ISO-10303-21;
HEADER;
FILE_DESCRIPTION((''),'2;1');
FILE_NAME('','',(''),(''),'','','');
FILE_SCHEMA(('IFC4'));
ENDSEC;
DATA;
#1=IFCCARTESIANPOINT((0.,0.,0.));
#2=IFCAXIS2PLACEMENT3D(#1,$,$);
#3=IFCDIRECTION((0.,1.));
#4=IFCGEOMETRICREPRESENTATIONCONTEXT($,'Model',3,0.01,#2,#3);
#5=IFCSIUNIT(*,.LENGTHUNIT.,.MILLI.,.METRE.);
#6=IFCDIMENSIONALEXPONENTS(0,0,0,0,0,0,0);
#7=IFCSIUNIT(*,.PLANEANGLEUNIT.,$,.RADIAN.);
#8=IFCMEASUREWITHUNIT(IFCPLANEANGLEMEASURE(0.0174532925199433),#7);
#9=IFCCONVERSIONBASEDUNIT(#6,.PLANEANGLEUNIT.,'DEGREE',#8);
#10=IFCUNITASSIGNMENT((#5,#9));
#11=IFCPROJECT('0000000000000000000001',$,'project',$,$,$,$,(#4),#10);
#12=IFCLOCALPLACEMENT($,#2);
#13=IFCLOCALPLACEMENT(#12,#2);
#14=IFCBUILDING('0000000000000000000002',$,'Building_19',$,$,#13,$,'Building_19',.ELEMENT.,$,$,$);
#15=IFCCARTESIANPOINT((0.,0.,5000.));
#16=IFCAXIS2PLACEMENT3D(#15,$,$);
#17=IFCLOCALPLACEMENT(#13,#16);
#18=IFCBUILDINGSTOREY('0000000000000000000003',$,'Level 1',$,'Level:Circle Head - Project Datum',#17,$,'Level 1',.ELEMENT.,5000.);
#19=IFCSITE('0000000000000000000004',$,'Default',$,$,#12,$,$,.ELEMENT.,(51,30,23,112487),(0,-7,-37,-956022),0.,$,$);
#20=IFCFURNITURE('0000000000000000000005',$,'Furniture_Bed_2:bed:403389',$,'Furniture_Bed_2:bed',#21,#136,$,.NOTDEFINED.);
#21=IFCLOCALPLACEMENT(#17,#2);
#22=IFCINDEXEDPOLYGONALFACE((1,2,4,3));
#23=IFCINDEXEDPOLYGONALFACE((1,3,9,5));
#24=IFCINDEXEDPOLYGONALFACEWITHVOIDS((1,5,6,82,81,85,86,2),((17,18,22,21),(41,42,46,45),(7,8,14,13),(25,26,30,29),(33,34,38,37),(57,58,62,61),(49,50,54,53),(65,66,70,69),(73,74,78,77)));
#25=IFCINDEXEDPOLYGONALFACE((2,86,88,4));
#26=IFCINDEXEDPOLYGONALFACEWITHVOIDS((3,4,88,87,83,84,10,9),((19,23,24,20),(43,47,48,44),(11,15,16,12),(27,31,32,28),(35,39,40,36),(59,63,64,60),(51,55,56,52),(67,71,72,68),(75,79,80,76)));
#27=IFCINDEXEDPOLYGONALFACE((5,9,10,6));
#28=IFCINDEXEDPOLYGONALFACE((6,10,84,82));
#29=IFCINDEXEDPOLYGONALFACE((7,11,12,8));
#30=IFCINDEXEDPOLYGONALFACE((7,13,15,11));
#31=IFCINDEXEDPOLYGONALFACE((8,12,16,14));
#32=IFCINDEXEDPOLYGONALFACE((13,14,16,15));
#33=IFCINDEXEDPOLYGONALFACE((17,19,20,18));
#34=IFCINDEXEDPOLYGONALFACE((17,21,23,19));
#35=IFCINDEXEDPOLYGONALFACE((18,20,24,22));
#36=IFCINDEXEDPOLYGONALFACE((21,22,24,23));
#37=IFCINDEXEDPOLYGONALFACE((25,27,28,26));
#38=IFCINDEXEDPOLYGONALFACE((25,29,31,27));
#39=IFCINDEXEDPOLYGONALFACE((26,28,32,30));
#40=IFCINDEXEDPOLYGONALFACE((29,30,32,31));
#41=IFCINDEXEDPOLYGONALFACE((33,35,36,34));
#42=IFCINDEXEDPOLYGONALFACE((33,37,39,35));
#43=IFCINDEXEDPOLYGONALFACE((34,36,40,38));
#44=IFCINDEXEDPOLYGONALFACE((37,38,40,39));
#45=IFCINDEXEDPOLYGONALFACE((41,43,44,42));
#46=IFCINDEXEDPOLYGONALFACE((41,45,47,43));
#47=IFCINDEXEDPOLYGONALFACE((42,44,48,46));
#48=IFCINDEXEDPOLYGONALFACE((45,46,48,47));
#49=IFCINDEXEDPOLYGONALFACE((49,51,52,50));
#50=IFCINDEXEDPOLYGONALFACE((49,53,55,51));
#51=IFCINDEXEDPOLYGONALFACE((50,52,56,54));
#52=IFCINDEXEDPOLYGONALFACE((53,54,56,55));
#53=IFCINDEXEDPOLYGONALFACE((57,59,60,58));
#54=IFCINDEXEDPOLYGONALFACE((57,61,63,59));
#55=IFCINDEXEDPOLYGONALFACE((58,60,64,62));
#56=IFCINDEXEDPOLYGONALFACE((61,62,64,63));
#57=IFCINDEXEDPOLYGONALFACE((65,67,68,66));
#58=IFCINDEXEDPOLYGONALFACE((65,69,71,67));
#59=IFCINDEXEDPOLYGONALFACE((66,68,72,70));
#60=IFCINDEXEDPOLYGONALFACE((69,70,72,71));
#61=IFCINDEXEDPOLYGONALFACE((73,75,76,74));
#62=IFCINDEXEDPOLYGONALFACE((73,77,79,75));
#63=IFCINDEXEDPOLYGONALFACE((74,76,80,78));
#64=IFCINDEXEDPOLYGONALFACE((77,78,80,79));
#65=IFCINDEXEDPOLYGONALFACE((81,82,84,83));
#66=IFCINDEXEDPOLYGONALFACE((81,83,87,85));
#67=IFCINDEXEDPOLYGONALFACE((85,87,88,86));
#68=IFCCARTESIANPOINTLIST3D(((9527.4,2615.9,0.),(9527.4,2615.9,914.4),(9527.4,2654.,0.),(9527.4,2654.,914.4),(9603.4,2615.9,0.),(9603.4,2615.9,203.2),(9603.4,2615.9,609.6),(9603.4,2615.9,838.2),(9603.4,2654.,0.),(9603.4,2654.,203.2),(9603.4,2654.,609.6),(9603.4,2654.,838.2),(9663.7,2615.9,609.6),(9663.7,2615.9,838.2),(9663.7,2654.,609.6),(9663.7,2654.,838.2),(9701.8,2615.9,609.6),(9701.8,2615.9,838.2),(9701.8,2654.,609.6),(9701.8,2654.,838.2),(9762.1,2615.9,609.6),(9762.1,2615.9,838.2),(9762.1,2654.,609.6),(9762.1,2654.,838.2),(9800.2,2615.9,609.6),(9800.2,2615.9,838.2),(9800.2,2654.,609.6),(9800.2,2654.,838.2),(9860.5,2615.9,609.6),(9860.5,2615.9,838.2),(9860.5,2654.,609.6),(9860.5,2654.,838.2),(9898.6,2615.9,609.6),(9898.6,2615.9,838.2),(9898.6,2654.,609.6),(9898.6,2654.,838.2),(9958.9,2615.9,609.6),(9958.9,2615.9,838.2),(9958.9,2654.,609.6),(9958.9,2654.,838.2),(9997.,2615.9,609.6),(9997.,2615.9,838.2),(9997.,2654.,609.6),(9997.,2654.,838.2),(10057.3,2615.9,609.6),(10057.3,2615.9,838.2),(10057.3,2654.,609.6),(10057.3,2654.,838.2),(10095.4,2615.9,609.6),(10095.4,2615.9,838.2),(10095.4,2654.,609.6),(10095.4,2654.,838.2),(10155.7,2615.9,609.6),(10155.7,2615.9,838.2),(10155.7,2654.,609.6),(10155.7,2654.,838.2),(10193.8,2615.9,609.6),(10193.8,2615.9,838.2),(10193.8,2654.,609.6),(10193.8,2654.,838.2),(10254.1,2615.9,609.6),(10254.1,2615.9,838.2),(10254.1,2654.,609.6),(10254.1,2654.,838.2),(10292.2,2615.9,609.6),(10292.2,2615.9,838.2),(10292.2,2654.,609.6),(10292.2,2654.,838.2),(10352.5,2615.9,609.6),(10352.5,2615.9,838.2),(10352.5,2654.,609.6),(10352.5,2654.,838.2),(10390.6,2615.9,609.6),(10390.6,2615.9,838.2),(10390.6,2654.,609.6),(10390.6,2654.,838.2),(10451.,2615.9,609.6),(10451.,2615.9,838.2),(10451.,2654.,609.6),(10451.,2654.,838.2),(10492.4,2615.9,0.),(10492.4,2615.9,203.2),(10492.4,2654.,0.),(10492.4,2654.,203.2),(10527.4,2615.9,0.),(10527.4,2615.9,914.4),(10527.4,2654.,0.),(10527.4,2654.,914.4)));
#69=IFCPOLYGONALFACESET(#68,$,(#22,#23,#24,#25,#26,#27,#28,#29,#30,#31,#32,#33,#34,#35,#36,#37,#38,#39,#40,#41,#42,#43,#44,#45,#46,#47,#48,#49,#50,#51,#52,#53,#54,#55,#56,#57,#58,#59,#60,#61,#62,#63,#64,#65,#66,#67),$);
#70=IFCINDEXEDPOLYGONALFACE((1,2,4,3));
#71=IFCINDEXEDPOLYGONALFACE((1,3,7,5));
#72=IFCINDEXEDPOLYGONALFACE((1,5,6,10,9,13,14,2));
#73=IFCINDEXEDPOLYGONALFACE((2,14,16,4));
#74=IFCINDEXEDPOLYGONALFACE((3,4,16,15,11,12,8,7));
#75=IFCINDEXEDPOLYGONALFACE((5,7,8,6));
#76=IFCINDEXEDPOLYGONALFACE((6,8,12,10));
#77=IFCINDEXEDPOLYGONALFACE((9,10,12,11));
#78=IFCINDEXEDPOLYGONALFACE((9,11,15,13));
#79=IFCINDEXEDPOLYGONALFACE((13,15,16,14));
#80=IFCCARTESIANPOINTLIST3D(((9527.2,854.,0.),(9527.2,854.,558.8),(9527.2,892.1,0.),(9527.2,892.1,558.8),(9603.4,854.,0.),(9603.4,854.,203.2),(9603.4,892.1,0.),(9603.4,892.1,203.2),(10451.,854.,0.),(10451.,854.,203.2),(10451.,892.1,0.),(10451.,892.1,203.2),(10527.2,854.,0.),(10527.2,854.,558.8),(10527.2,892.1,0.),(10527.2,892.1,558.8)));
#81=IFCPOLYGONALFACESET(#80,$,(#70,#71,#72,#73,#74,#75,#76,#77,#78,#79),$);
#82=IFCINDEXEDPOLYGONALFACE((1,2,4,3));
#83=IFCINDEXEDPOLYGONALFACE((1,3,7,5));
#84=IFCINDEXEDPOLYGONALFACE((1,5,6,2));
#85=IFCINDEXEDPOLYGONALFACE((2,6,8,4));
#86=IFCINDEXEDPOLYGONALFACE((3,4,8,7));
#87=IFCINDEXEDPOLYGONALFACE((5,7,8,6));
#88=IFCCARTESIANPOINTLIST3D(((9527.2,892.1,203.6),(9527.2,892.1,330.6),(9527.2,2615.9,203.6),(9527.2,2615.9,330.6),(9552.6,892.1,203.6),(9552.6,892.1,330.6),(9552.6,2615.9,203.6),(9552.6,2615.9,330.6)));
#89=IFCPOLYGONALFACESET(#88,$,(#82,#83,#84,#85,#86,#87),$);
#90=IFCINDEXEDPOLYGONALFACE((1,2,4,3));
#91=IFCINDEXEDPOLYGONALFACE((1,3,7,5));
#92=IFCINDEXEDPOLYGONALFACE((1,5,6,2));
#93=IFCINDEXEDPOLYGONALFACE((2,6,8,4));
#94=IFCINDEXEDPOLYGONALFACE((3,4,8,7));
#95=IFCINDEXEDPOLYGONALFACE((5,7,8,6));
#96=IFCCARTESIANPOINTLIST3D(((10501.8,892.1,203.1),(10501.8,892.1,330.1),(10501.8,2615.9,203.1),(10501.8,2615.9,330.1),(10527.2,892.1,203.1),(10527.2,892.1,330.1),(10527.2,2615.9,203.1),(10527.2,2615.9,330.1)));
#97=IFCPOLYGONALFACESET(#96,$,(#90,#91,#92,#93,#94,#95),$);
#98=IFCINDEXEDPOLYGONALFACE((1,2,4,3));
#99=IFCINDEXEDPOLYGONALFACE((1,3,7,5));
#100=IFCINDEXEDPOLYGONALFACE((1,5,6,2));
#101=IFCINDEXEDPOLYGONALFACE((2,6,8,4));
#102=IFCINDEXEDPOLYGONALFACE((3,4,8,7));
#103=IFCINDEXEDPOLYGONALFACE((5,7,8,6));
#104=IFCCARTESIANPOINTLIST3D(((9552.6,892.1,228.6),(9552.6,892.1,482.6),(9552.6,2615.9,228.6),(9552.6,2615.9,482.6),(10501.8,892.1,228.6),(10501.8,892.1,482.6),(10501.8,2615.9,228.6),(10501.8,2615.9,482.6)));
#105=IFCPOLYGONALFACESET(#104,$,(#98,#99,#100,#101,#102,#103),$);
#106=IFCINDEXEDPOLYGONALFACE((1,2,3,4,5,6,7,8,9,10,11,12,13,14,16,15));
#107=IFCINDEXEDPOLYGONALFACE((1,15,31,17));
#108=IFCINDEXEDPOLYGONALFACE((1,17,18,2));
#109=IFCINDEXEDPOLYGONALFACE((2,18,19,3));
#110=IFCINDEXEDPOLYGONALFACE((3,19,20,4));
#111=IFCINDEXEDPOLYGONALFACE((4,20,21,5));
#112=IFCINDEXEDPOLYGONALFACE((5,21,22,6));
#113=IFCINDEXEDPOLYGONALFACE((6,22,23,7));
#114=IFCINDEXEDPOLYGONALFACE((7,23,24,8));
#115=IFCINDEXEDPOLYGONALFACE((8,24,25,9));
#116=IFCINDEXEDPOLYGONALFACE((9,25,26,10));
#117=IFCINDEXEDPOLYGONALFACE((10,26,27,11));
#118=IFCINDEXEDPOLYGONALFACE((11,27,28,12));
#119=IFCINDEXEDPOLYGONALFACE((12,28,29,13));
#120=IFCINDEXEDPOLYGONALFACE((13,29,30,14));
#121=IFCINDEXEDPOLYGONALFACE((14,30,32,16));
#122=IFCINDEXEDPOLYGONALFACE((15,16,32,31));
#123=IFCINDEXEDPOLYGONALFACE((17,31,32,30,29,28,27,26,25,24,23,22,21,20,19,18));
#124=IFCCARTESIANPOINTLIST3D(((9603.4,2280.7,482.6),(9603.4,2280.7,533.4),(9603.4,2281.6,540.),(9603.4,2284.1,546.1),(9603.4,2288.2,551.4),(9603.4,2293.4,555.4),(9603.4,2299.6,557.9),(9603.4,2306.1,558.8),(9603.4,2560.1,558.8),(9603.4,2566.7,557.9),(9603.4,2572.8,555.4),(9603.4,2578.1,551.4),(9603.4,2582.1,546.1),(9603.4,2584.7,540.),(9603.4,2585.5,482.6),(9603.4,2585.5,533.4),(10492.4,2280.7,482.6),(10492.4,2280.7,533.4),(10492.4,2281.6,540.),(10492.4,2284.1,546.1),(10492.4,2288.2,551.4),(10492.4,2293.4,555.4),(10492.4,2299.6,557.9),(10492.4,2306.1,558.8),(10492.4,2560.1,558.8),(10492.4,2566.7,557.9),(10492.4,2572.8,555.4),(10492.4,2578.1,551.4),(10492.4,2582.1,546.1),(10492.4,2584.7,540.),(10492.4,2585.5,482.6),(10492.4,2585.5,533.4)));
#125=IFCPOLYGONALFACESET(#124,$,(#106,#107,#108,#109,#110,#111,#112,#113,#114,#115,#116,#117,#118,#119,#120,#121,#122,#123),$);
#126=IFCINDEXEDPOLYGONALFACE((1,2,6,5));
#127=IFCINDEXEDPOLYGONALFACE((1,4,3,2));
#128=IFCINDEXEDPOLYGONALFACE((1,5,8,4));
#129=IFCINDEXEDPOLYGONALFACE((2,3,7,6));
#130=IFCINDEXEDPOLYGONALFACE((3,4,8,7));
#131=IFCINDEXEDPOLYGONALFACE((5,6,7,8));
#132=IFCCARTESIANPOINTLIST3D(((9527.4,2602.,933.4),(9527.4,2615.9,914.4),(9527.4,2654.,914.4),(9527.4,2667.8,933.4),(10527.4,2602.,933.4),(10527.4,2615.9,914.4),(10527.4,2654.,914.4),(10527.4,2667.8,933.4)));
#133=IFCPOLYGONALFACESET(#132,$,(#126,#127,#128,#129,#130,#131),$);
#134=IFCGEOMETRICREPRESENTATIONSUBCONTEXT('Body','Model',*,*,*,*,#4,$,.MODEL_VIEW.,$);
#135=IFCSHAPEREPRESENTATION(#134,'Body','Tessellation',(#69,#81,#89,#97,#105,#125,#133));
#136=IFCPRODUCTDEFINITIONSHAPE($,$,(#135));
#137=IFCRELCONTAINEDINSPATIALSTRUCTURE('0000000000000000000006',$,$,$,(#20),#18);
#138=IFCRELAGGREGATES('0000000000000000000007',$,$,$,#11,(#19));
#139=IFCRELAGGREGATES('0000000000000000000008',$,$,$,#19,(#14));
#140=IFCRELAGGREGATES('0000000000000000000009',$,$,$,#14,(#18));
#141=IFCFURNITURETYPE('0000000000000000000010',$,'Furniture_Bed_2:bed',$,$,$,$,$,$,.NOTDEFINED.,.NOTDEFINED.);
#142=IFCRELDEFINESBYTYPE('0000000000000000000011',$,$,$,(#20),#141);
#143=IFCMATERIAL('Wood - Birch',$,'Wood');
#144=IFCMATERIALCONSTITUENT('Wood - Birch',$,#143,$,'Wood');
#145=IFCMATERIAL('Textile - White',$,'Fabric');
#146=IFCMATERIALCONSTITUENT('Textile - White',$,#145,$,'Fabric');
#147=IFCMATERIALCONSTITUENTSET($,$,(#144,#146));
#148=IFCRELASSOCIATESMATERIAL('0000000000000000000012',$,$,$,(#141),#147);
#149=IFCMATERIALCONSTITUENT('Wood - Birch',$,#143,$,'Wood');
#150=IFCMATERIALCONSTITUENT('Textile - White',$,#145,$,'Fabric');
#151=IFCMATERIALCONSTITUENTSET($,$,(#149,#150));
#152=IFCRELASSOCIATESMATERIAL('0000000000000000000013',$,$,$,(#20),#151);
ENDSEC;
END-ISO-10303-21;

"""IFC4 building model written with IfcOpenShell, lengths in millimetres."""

from ifc_helpers import new_model, entity, si_unit, converted_unit, direction, frame, origin, place, context, subcontext, project, spatial, line, arc, indexed_curve, outline, extrude, source, transform, mapped, material, constituent, constituent_set, type_object, type_shapes, element, save


model = new_model("IFC4")

# Units and contexts
model_context = context("Model", 3, precision=0.01, world=origin(), true_north=direction((0.0, 1.0)))
body_context = subcontext(model_context, "Body", "Model", "MODEL_VIEW")
ifc_project = project(units=[si_unit("LENGTHUNIT", "METRE", prefix="MILLI"), converted_unit("PLANEANGLEUNIT", "DEGREE", entity("IfcPlaneAngleMeasure", 0.0174532925199433), si_unit("PLANEANGLEUNIT", "RADIAN"), dimensions=[0, 0, 0, 0, 0, 0, 0])], contexts=[model_context])

# Site, building, storey
site_placement = place(None, origin())
site = spatial("IfcSite", under=ifc_project, at=site_placement, Name="Default", CompositionType="ELEMENT", RefLatitude=(51, 30, 23, 112487), RefLongitude=(0, -7, -37, -956022), RefElevation=0.0)
building_placement = place(site_placement, origin())
building = spatial("IfcBuilding", under=site, at=building_placement, Name="Building_19", LongName="Building_19", CompositionType="ELEMENT")
storey_placement = place(building_placement, frame((0.0, 0.0, 5000.0)))
storey = spatial("IfcBuildingStorey", under=building, at=storey_placement, Name="Level 1", ObjectType="Level:Circle Head - Project Datum", LongName="Level 1", CompositionType="ELEMENT", Elevation=5000.0)

# Furniture
ifc_material_1 = material(Name="Wood - Birch", Category="Wood")
ifc_material_2 = material(Name="Textile - White", Category="Fabric")
ifc_constituent_1 = constituent(ifc_material_1, Name="Wood - Birch", Category="Wood")
ifc_constituent_2 = constituent(ifc_material_2, Name="Textile - White", Category="Fabric")
ifc_constituent_set_1 = constituent_set(constituents=[ifc_constituent_1, ifc_constituent_2])
furniture_type_1 = type_object("IfcFurnitureType", Name="Furniture_Bed_2:bed", AssemblyPlace="NOTDEFINED", PredefinedType="NOTDEFINED", material=ifc_constituent_set_1)
shared_shape_1 = source(origin(), body_context, "Body", "SweptSolid", [
    extrude(outline(indexed_curve([(-635.0, -489.8), (279.4, -489.8), (279.4, -454.7), (76.2, -454.7), (76.2, 434.3), (279.4, 434.3), (279.4, 510.3), (-635.0, 510.3), (-635.0, -489.8)], self_intersect=False), holes=[indexed_curve([(-558.8, 374.0), (-558.8, 434.3), (-330.2, 434.3), (-330.2, 374.0), (-558.8, 374.0)], self_intersect=False), indexed_curve([(-558.8, 275.5), (-558.8, 335.9), (-330.2, 335.9), (-330.2, 275.5), (-558.8, 275.5)], self_intersect=False), indexed_curve([(-558.8, 177.1), (-558.8, 237.4), (-330.2, 237.4), (-330.2, 177.1), (-558.8, 177.1)], self_intersect=False), indexed_curve([(-558.8, 78.7), (-558.8, 139.0), (-330.2, 139.0), (-330.2, 78.7), (-558.8, 78.7)], self_intersect=False), indexed_curve([(-558.8, -118.1), (-558.8, -57.8), (-330.2, -57.8), (-330.2, -118.1), (-558.8, -118.1)], self_intersect=False), indexed_curve([(-558.8, -216.5), (-558.8, -156.2), (-330.2, -156.2), (-330.2, -216.5), (-558.8, -216.5)], self_intersect=False), indexed_curve([(-558.8, -314.9), (-558.8, -254.6), (-330.2, -254.6), (-330.2, -314.9), (-558.8, -314.9)], self_intersect=False), indexed_curve([(-558.8, -413.3), (-558.8, -353.0), (-330.2, -353.0), (-330.2, -413.3), (-558.8, -413.3)], self_intersect=False), indexed_curve([(-558.8, -19.7), (-558.8, 40.6), (-330.2, 40.6), (-330.2, -19.7), (-558.8, -19.7)], self_intersect=False)]), frame((-8.6, -38.1, 279.4), z_axis=(0.0, 1.0, 0.0), x_axis=(0.0, 0.0, -1.0)), (0.0, 0.0, 1.0), 38.1),
    extrude(outline(indexed_curve([(423.8, -190.5), (500.0, -190.5), (500.0, 368.3), (-500.0, 368.3), (-500.0, -190.5), (-423.8, -190.5), (-423.8, 12.7), (423.8, 12.7), (423.8, -190.5)], self_intersect=False)), frame((-19.1, -1800.0, 190.5), z_axis=(0.0, 1.0, 0.0), x_axis=(-1.0, 0.0, 0.0)), (0.0, 0.0, 1.0), 38.1),
    extrude(outline(indexed_curve([(-12.7, -861.9), (12.7, -861.9), (12.7, 861.9), (-12.7, 861.9), (-12.7, -861.9)], self_intersect=False)), frame((-506.4, -900.0, 203.6)), (0.0, 0.0, 1.0), 127.0),
    extrude(outline(indexed_curve([(-12.7, -861.9), (12.7, -861.9), (12.7, 861.9), (-12.7, 861.9), (-12.7, -861.9)], self_intersect=False)), frame((468.2, -900.0, 203.1)), (0.0, 0.0, 1.0), 127.0),
    extrude(outline(indexed_curve([(-474.6, -861.9), (474.6, -861.9), (474.6, 861.9), (-474.6, 861.9), (-474.6, -861.9)], self_intersect=False)), frame((-19.0, -900.0, 228.6), z_axis=(0.0, 0.0, 1.0), x_axis=(-1.0, 0.0, 0.0)), (0.0, 0.0, 1.0), 254.0),
    extrude(outline(indexed_curve([(-152.4, -42.3), (152.4, -42.3), (152.4, 8.5), (145.0, 26.4), (127.0, 33.9), (-127.0, 33.9), (-145.0, 26.4), (-152.4, 8.5)], segments=[line(1, 2, 3), arc(3, 4, 5), line(5, 6), arc(6, 7, 8), line(8, 1)], self_intersect=False)), frame((-442.9, -220.8, 524.9), z_axis=(1.0, 0.0, 0.0), x_axis=(0.0, 1.0, 0.0)), (0.0, 0.0, 1.0), 889.0),
    extrude(outline(indexed_curve([(-19.1, -9.5), (19.0, -9.5), (32.9, 9.5), (-32.9, 9.5), (-19.1, -9.5)], self_intersect=False)), frame((-518.8, -19.0, 923.9), z_axis=(1.0, 0.0, 0.0), x_axis=(0.0, 1.0, 0.0)), (0.0, 0.0, 1.0), 1000.1),
])
type_shapes(furniture_type_1, [shared_shape_1])
ifc_constituent_3 = constituent(ifc_material_1, Name="Wood - Birch", Category="Wood")
ifc_constituent_4 = constituent(ifc_material_2, Name="Textile - White", Category="Fabric")
ifc_constituent_set_2 = constituent_set(constituents=[ifc_constituent_3, ifc_constituent_4])
furniture_1_placement = place(storey_placement, frame((10046.2, 2654.0, 0.0)))
element("IfcFurniture", 1, at=furniture_1_placement, inside=storey, type_object=furniture_type_1, material=ifc_constituent_set_2, Name="Furniture_Bed_2:bed:403389", ObjectType="Furniture_Bed_2:bed", PredefinedType="NOTDEFINED", context=body_context, shape_type="MappedRepresentation", body=[
    mapped(shared_shape_1, transform((0.0, 0.0, 0.0), scale=1.0)),
])

save(model, "model.ifc")
